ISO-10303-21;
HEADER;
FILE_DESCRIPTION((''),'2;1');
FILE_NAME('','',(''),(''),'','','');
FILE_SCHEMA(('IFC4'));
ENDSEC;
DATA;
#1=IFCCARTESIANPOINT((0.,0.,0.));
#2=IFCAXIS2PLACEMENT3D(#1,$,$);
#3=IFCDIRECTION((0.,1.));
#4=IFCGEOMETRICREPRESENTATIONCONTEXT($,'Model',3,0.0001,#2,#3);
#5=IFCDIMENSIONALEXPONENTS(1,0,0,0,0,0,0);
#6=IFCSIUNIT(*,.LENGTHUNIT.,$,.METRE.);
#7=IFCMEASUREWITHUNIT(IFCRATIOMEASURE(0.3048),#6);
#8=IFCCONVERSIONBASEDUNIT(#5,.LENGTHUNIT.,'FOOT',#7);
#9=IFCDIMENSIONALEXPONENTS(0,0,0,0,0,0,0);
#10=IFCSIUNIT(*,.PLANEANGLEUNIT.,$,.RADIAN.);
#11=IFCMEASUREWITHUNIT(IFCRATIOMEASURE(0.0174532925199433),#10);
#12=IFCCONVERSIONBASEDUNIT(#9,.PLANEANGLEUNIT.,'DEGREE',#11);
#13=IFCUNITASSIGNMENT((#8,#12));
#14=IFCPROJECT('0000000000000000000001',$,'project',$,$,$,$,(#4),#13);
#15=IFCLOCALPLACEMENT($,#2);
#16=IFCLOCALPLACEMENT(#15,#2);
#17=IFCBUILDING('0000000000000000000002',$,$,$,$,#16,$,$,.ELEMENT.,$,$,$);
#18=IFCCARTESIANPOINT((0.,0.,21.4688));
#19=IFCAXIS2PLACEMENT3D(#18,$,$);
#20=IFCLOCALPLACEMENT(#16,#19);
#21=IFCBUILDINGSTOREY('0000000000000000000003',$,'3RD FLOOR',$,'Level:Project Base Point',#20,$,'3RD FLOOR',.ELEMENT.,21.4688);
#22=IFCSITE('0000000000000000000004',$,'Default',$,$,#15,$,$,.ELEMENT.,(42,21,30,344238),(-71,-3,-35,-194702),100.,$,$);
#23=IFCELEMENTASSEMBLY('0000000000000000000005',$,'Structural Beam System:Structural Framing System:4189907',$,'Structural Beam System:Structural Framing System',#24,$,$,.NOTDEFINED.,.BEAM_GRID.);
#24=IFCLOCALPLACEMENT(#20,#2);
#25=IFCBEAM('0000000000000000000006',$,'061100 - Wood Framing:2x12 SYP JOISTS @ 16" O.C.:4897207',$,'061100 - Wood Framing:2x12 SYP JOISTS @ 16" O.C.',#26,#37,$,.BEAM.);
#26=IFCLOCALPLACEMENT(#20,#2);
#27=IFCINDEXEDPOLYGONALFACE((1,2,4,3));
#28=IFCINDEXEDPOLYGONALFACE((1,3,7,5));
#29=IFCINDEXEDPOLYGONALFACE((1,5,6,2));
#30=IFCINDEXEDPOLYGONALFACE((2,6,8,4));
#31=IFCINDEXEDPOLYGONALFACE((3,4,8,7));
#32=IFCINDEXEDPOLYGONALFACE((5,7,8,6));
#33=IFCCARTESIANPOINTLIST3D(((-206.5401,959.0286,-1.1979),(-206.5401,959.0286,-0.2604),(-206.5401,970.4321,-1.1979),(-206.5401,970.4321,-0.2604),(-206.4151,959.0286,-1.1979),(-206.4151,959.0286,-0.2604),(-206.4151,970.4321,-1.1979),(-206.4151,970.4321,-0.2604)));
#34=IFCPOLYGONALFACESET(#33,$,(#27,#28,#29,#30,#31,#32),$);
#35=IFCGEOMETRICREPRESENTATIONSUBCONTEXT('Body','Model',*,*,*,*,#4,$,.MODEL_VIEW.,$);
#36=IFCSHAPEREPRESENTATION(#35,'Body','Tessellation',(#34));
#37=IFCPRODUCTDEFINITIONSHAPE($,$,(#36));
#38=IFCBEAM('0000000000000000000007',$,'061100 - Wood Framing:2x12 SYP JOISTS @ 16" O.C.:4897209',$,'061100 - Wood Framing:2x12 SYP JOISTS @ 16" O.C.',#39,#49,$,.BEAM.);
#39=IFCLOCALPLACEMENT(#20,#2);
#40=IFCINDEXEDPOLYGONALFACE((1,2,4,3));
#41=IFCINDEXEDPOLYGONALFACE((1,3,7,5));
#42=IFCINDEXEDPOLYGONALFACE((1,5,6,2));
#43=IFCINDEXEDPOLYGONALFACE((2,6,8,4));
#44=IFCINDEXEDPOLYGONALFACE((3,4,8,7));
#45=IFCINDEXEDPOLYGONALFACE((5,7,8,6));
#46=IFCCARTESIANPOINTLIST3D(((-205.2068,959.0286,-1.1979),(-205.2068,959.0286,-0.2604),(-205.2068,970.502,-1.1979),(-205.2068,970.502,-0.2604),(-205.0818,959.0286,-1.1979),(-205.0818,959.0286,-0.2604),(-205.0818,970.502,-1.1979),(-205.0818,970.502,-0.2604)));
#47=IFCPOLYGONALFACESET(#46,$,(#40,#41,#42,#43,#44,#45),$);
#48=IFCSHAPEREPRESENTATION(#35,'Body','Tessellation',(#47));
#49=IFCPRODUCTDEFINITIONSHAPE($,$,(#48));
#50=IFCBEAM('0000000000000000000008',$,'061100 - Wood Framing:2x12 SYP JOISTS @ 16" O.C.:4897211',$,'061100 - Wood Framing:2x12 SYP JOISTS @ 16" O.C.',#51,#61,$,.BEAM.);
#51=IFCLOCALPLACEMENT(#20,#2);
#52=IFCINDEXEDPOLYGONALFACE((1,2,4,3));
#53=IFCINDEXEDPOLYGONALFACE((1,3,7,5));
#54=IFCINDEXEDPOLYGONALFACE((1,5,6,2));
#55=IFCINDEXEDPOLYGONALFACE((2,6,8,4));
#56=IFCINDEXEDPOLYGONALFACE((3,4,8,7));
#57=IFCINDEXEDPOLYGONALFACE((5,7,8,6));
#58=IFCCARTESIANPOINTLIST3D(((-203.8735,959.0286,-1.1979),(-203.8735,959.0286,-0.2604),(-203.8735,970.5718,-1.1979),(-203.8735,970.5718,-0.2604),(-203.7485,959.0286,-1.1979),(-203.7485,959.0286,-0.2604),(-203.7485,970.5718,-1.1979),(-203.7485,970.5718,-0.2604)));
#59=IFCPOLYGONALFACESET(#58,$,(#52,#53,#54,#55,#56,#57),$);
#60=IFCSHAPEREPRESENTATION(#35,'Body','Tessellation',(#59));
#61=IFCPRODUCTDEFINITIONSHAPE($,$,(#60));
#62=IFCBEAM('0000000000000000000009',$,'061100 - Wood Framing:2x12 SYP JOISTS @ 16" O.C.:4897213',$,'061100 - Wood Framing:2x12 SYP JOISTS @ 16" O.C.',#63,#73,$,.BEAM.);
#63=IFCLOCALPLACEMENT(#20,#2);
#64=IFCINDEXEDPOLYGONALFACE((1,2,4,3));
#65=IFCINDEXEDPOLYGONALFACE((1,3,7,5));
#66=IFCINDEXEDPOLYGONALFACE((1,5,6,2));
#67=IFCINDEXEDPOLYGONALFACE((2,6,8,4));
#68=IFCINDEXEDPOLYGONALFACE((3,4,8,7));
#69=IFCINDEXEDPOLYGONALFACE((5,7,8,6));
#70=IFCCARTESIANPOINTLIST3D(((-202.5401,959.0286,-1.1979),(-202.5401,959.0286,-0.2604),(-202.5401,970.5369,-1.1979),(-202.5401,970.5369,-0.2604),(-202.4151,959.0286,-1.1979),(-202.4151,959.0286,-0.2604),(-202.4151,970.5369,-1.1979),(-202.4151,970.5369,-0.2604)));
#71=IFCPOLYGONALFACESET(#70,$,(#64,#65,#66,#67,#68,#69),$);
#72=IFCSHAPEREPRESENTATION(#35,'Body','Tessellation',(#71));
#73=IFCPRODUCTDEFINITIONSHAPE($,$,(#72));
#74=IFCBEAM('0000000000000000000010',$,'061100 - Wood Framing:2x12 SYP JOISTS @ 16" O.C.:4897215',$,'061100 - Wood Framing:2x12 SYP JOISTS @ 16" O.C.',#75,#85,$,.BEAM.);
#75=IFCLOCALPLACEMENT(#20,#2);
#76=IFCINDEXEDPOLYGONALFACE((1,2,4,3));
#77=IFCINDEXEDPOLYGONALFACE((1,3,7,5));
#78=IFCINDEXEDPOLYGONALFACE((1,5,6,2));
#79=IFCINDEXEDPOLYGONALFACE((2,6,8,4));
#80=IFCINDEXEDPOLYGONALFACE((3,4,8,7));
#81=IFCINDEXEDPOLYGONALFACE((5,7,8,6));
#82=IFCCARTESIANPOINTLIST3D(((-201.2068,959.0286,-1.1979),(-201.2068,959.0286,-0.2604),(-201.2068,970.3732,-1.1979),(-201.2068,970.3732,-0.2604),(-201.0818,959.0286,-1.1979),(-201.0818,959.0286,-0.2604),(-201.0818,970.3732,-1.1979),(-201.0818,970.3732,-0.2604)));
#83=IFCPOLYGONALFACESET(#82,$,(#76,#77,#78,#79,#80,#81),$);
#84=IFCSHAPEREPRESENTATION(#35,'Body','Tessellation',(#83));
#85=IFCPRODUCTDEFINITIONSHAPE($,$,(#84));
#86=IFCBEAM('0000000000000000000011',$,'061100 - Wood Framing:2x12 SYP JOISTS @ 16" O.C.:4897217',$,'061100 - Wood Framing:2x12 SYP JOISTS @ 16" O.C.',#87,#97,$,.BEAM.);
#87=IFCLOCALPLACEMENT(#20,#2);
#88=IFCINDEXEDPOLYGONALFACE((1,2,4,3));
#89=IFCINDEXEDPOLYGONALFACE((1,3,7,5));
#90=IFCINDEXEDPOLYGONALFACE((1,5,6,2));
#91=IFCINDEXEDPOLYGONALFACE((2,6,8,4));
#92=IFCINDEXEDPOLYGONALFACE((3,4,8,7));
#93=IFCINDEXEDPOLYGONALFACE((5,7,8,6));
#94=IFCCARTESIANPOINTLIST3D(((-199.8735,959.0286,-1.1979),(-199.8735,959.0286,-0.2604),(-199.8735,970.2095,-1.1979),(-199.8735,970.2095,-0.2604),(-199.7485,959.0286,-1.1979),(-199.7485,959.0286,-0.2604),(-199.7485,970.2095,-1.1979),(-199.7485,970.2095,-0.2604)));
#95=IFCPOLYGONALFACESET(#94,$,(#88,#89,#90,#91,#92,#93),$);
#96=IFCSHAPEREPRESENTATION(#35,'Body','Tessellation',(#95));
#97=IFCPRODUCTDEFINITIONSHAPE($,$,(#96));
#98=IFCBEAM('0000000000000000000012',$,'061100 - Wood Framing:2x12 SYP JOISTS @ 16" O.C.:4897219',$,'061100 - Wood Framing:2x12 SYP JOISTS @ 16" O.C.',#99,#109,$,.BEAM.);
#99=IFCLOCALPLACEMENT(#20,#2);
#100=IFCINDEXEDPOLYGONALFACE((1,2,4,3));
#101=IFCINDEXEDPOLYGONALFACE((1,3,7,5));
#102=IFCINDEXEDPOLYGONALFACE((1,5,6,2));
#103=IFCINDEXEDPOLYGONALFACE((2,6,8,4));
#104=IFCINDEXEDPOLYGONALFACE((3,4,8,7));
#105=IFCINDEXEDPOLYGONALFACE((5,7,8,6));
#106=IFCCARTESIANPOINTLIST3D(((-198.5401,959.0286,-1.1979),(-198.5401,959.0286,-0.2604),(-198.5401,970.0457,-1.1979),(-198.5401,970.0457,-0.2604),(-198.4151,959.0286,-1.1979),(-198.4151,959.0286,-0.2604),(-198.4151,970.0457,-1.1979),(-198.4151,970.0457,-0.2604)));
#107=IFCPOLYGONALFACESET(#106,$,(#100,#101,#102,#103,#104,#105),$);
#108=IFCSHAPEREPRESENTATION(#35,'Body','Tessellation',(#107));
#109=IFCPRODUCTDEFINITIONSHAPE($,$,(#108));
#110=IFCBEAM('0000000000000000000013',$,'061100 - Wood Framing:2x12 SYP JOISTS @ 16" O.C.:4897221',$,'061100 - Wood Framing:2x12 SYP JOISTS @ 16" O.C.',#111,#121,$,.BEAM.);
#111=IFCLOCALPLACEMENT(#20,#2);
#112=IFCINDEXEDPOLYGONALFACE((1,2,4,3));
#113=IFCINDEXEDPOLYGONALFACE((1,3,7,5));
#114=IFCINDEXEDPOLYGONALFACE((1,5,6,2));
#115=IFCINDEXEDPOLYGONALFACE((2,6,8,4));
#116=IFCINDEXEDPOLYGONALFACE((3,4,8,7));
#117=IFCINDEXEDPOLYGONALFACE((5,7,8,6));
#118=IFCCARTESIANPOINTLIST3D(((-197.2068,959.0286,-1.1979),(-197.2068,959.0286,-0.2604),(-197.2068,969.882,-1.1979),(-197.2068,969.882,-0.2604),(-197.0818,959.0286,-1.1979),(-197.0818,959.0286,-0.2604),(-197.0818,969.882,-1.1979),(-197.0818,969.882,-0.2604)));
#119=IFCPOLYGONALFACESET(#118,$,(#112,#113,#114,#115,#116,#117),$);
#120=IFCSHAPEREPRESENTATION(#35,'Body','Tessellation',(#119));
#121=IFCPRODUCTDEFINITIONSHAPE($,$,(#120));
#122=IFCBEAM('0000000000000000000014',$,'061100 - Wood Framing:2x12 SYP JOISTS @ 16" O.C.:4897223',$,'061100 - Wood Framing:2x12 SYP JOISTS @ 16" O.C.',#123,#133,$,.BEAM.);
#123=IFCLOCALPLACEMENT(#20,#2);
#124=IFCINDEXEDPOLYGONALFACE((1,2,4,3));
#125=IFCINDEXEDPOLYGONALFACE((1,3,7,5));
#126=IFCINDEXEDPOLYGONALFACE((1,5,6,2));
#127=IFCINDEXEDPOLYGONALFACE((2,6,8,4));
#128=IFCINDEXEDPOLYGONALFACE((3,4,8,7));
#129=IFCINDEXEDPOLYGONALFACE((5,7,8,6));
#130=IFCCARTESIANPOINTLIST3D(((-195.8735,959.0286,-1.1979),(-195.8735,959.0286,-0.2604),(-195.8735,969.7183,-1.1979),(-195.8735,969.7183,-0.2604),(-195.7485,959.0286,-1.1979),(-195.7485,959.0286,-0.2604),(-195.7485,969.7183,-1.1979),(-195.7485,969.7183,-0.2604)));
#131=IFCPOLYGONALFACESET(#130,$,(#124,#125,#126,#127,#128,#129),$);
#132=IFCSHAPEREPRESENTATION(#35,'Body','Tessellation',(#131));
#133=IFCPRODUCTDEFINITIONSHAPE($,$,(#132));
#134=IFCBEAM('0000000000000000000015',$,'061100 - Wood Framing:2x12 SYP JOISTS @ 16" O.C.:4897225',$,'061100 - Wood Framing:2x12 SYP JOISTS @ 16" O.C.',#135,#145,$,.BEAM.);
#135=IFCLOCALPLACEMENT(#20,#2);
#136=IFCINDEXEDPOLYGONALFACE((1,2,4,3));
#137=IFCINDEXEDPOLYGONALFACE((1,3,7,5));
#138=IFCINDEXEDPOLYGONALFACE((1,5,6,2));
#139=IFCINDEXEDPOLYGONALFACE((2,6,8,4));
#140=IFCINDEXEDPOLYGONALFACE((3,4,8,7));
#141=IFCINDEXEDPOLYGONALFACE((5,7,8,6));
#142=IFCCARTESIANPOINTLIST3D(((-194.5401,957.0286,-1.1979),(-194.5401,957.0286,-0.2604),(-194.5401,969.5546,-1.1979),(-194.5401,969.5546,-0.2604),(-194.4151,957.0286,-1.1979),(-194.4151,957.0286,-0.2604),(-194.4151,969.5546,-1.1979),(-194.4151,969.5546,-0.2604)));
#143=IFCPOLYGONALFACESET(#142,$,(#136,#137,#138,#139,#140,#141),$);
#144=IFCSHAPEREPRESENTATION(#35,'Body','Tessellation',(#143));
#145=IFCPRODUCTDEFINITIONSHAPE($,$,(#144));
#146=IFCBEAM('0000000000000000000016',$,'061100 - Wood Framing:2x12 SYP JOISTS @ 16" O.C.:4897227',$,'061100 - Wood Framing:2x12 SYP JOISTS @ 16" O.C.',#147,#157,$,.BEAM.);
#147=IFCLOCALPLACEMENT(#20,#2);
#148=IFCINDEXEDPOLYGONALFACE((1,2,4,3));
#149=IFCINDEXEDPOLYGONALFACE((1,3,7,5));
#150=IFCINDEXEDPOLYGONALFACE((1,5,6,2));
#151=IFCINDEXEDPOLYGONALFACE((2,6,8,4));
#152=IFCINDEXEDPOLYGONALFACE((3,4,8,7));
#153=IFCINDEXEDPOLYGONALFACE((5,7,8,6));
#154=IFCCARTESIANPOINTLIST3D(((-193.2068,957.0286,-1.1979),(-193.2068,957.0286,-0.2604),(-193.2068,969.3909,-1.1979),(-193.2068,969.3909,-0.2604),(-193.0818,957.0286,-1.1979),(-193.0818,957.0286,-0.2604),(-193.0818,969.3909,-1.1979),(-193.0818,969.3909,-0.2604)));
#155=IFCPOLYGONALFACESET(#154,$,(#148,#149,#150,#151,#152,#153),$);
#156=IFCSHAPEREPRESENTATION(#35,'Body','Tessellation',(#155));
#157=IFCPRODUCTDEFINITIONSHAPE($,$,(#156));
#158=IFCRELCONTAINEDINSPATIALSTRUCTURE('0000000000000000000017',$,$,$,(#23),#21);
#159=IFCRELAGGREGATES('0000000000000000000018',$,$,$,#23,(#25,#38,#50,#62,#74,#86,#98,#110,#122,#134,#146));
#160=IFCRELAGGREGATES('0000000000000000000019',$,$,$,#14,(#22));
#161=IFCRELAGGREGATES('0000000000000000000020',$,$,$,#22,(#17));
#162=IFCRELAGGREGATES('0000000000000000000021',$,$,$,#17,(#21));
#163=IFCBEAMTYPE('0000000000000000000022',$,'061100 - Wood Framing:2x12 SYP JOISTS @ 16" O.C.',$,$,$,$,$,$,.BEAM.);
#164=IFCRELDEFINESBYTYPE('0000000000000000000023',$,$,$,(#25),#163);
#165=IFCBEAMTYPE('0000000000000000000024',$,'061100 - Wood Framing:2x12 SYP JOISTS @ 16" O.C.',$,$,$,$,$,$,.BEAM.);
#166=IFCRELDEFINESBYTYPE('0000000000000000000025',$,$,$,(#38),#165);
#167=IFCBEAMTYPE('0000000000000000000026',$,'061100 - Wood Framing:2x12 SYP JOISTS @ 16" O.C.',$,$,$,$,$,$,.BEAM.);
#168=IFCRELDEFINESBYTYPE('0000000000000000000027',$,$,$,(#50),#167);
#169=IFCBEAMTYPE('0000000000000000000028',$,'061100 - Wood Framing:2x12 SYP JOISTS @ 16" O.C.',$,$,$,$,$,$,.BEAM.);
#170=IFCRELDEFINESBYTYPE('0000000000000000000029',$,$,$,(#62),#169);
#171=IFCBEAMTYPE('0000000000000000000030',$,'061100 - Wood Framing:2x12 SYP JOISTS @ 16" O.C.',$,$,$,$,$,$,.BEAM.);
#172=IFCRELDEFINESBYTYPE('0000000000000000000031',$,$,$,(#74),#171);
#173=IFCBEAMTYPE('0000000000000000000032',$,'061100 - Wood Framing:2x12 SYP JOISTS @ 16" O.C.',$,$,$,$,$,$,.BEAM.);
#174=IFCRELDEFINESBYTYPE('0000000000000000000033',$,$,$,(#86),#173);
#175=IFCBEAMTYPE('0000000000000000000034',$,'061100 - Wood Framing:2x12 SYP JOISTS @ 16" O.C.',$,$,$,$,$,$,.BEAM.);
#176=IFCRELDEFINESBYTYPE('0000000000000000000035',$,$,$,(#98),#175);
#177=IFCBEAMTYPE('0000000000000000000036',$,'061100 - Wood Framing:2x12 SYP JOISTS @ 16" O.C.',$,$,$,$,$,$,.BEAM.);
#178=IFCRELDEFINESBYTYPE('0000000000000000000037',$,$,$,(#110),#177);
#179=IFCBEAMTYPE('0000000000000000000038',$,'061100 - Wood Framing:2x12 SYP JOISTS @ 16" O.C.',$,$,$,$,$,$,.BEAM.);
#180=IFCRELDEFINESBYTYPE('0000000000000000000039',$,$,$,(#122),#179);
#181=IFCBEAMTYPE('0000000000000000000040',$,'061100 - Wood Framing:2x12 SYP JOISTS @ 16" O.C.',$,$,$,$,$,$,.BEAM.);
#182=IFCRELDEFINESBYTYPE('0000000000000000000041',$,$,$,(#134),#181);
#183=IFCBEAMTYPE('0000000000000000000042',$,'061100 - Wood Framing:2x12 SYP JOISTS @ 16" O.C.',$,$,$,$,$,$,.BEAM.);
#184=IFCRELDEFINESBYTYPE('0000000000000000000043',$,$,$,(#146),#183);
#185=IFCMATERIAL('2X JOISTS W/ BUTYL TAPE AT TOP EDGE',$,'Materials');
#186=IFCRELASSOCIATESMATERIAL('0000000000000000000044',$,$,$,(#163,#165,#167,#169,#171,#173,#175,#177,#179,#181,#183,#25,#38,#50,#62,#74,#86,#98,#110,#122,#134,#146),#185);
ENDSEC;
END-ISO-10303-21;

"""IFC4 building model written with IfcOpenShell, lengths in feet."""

from ifc_helpers import new_model, entity, si_unit, converted_unit, direction, frame, origin, origin_2d_with_axis, place, context, subcontext, project, spatial, rectangle, extrude, source, transform, mapped, material, material_profile, profile_set, profile_usage, type_object, type_shapes, element, aggregate, save


model = new_model("IFC4")

# Units and contexts
model_context = context("Model", 3, precision=0.0001, world=origin(), true_north=direction((0.0, 1.0)))
body_context = subcontext(model_context, "Body", "Model", "MODEL_VIEW")
ifc_project = project(units=[converted_unit("LENGTHUNIT", "FOOT", entity("IfcRatioMeasure", 0.3048), si_unit("LENGTHUNIT", "METRE"), dimensions=[1, 0, 0, 0, 0, 0, 0]), converted_unit("PLANEANGLEUNIT", "DEGREE", entity("IfcRatioMeasure", 0.0174532925199433), si_unit("PLANEANGLEUNIT", "RADIAN"), dimensions=[0, 0, 0, 0, 0, 0, 0])], contexts=[model_context])

# Site, building, storey
site_placement = place(None, origin())
site = spatial("IfcSite", under=ifc_project, at=site_placement, Name="Default", CompositionType="ELEMENT", RefLatitude=(42, 21, 30, 344238), RefLongitude=(-71, -3, -35, -194702), RefElevation=100.0)
building_placement = place(site_placement, origin())
building = spatial("IfcBuilding", under=site, at=building_placement, CompositionType="ELEMENT")
storey_placement = place(building_placement, frame((0.0, 0.0, 21.4688)))
storey = spatial("IfcBuildingStorey", under=building, at=storey_placement, Name="3RD FLOOR", ObjectType="Level:Project Base Point", LongName="3RD FLOOR", CompositionType="ELEMENT", Elevation=21.4688)

# Element assembly, beams
assembly_1_placement = place(storey_placement, origin())
assembly_1 = element("IfcElementAssembly", 1, at=assembly_1_placement, inside=storey, Name="Structural Beam System:Structural Framing System:4189907", ObjectType="Structural Beam System:Structural Framing System", AssemblyPlace="NOTDEFINED", PredefinedType="BEAM_GRID")
ifc_material_1 = material(Name="2X JOISTS W/ BUTYL TAPE AT TOP EDGE", Category="Materials")
ifc_material_profile_1 = material_profile(ifc_material_1, rectangle(XDim=0.9375, YDim=0.125, at=origin_2d_with_axis()), Name="2x12 SYP JOISTS @ 16\" O.C.")
ifc_profile_set_1 = profile_set([ifc_material_profile_1], Name="2x12 SYP JOISTS @ 16\" O.C.")
ifc_profile_usage_1 = profile_usage(ifc_profile_set_1, cardinal=8)
beam_type_1 = type_object("IfcBeamType", Name="061100 - Wood Framing:2x12 SYP JOISTS @ 16\" O.C.", PredefinedType="BEAM", material=ifc_profile_set_1)
shared_shape_1 = source(origin(), body_context, "Body", "SweptSolid", [
    extrude(rectangle(XDim=0.9375, YDim=0.125, at=origin_2d_with_axis()), frame((-5.7017, 0.0, 0.0), z_axis=(1.0, 0.0, 0.0), x_axis=(0.0, 0.0, -1.0)), (0.0, 0.0, 1.0), 11.4035),
])
type_shapes(beam_type_1, [shared_shape_1])
beam_1_placement = place(assembly_1_placement, frame((-206.4776, 964.7303, -0.7292), z_axis=(0.0, 0.0, 1.0), x_axis=(0.0, 1.0, 0.0)))
beam_1 = element("IfcBeam", 2, at=beam_1_placement, type_object=beam_type_1, material=ifc_profile_usage_1, Name="061100 - Wood Framing:2x12 SYP JOISTS @ 16\" O.C.:4897207", ObjectType="061100 - Wood Framing:2x12 SYP JOISTS @ 16\" O.C.", PredefinedType="BEAM", context=body_context, shape_type="MappedRepresentation", body=[
    mapped(shared_shape_1, transform((0.0, 0.0, 0.0), scale=1.0)),
])
ifc_profile_usage_2 = profile_usage(ifc_profile_set_1, cardinal=8)
beam_type_2 = type_object("IfcBeamType", Name="061100 - Wood Framing:2x12 SYP JOISTS @ 16\" O.C.", PredefinedType="BEAM", material=ifc_profile_set_1)
shared_shape_2 = source(origin(), body_context, "Body", "SweptSolid", [
    extrude(rectangle(XDim=0.9375, YDim=0.125, at=origin_2d_with_axis()), frame((-5.7367, 0.0, 0.0), z_axis=(1.0, 0.0, 0.0), x_axis=(0.0, 0.0, -1.0)), (0.0, 0.0, 1.0), 11.4734),
])
type_shapes(beam_type_2, [shared_shape_2])
beam_2_placement = place(assembly_1_placement, frame((-205.1443, 964.7653, -0.7292), z_axis=(0.0, 0.0, 1.0), x_axis=(0.0, 1.0, 0.0)))
beam_2 = element("IfcBeam", 3, at=beam_2_placement, type_object=beam_type_2, material=ifc_profile_usage_2, Name="061100 - Wood Framing:2x12 SYP JOISTS @ 16\" O.C.:4897209", ObjectType="061100 - Wood Framing:2x12 SYP JOISTS @ 16\" O.C.", PredefinedType="BEAM", context=body_context, shape_type="MappedRepresentation", body=[
    mapped(shared_shape_2, transform((0.0, 0.0, 0.0), scale=1.0)),
])
ifc_profile_usage_3 = profile_usage(ifc_profile_set_1, cardinal=8)
beam_type_3 = type_object("IfcBeamType", Name="061100 - Wood Framing:2x12 SYP JOISTS @ 16\" O.C.", PredefinedType="BEAM", material=ifc_profile_set_1)
shared_shape_3 = source(origin(), body_context, "Body", "SweptSolid", [
    extrude(rectangle(XDim=0.9375, YDim=0.125, at=origin_2d_with_axis()), frame((-5.7716, 0.0, 0.0), z_axis=(1.0, 0.0, 0.0), x_axis=(0.0, 0.0, -1.0)), (0.0, 0.0, 1.0), 11.5432),
])
type_shapes(beam_type_3, [shared_shape_3])
beam_3_placement = place(assembly_1_placement, frame((-203.811, 964.8002, -0.7292), z_axis=(0.0, 0.0, 1.0), x_axis=(0.0, 1.0, 0.0)))
beam_3 = element("IfcBeam", 4, at=beam_3_placement, type_object=beam_type_3, material=ifc_profile_usage_3, Name="061100 - Wood Framing:2x12 SYP JOISTS @ 16\" O.C.:4897211", ObjectType="061100 - Wood Framing:2x12 SYP JOISTS @ 16\" O.C.", PredefinedType="BEAM", context=body_context, shape_type="MappedRepresentation", body=[
    mapped(shared_shape_3, transform((0.0, 0.0, 0.0), scale=1.0)),
])
ifc_profile_usage_4 = profile_usage(ifc_profile_set_1, cardinal=8)
beam_type_4 = type_object("IfcBeamType", Name="061100 - Wood Framing:2x12 SYP JOISTS @ 16\" O.C.", PredefinedType="BEAM", material=ifc_profile_set_1)
shared_shape_4 = source(origin(), body_context, "Body", "SweptSolid", [
    extrude(rectangle(XDim=0.9375, YDim=0.125, at=origin_2d_with_axis()), frame((-5.7541, 0.0, 0.0), z_axis=(1.0, 0.0, 0.0), x_axis=(0.0, 0.0, -1.0)), (0.0, 0.0, 1.0), 11.5083),
])
type_shapes(beam_type_4, [shared_shape_4])
beam_4_placement = place(assembly_1_placement, frame((-202.4776, 964.7827, -0.7292), z_axis=(0.0, 0.0, 1.0), x_axis=(0.0, 1.0, 0.0)))
beam_4 = element("IfcBeam", 5, at=beam_4_placement, type_object=beam_type_4, material=ifc_profile_usage_4, Name="061100 - Wood Framing:2x12 SYP JOISTS @ 16\" O.C.:4897213", ObjectType="061100 - Wood Framing:2x12 SYP JOISTS @ 16\" O.C.", PredefinedType="BEAM", context=body_context, shape_type="MappedRepresentation", body=[
    mapped(shared_shape_4, transform((0.0, 0.0, 0.0), scale=1.0)),
])
ifc_profile_usage_5 = profile_usage(ifc_profile_set_1, cardinal=8)
beam_type_5 = type_object("IfcBeamType", Name="061100 - Wood Framing:2x12 SYP JOISTS @ 16\" O.C.", PredefinedType="BEAM", material=ifc_profile_set_1)
shared_shape_5 = source(origin(), body_context, "Body", "SweptSolid", [
    extrude(rectangle(XDim=0.9375, YDim=0.125, at=origin_2d_with_axis()), frame((-5.6723, 0.0, 0.0), z_axis=(1.0, 0.0, 0.0), x_axis=(0.0, 0.0, -1.0)), (0.0, 0.0, 1.0), 11.3446),
])
type_shapes(beam_type_5, [shared_shape_5])
beam_5_placement = place(assembly_1_placement, frame((-201.1443, 964.7009, -0.7292), z_axis=(0.0, 0.0, 1.0), x_axis=(0.0, 1.0, 0.0)))
beam_5 = element("IfcBeam", 6, at=beam_5_placement, type_object=beam_type_5, material=ifc_profile_usage_5, Name="061100 - Wood Framing:2x12 SYP JOISTS @ 16\" O.C.:4897215", ObjectType="061100 - Wood Framing:2x12 SYP JOISTS @ 16\" O.C.", PredefinedType="BEAM", context=body_context, shape_type="MappedRepresentation", body=[
    mapped(shared_shape_5, transform((0.0, 0.0, 0.0), scale=1.0)),
])
ifc_profile_usage_6 = profile_usage(ifc_profile_set_1, cardinal=8)
beam_type_6 = type_object("IfcBeamType", Name="061100 - Wood Framing:2x12 SYP JOISTS @ 16\" O.C.", PredefinedType="BEAM", material=ifc_profile_set_1)
shared_shape_6 = source(origin(), body_context, "Body", "SweptSolid", [
    extrude(rectangle(XDim=0.9375, YDim=0.125, at=origin_2d_with_axis()), frame((-5.5904, 0.0, 0.0), z_axis=(1.0, 0.0, 0.0), x_axis=(0.0, 0.0, -1.0)), (0.0, 0.0, 1.0), 11.1809),
])
type_shapes(beam_type_6, [shared_shape_6])
beam_6_placement = place(assembly_1_placement, frame((-199.811, 964.619, -0.7292), z_axis=(0.0, 0.0, 1.0), x_axis=(0.0, 1.0, 0.0)))
beam_6 = element("IfcBeam", 7, at=beam_6_placement, type_object=beam_type_6, material=ifc_profile_usage_6, Name="061100 - Wood Framing:2x12 SYP JOISTS @ 16\" O.C.:4897217", ObjectType="061100 - Wood Framing:2x12 SYP JOISTS @ 16\" O.C.", PredefinedType="BEAM", context=body_context, shape_type="MappedRepresentation", body=[
    mapped(shared_shape_6, transform((0.0, 0.0, 0.0), scale=1.0)),
])
ifc_profile_usage_7 = profile_usage(ifc_profile_set_1, cardinal=8)
beam_type_7 = type_object("IfcBeamType", Name="061100 - Wood Framing:2x12 SYP JOISTS @ 16\" O.C.", PredefinedType="BEAM", material=ifc_profile_set_1)
shared_shape_7 = source(origin(), body_context, "Body", "SweptSolid", [
    extrude(rectangle(XDim=0.9375, YDim=0.125, at=origin_2d_with_axis()), frame((-5.5086, 0.0, 0.0), z_axis=(1.0, 0.0, 0.0), x_axis=(0.0, 0.0, -1.0)), (0.0, 0.0, 1.0), 11.0171),
])
type_shapes(beam_type_7, [shared_shape_7])
beam_7_placement = place(assembly_1_placement, frame((-198.4776, 964.5372, -0.7292), z_axis=(0.0, 0.0, 1.0), x_axis=(0.0, 1.0, 0.0)))
beam_7 = element("IfcBeam", 8, at=beam_7_placement, type_object=beam_type_7, material=ifc_profile_usage_7, Name="061100 - Wood Framing:2x12 SYP JOISTS @ 16\" O.C.:4897219", ObjectType="061100 - Wood Framing:2x12 SYP JOISTS @ 16\" O.C.", PredefinedType="BEAM", context=body_context, shape_type="MappedRepresentation", body=[
    mapped(shared_shape_7, transform((0.0, 0.0, 0.0), scale=1.0)),
])
ifc_profile_usage_8 = profile_usage(ifc_profile_set_1, cardinal=8)
beam_type_8 = type_object("IfcBeamType", Name="061100 - Wood Framing:2x12 SYP JOISTS @ 16\" O.C.", PredefinedType="BEAM", material=ifc_profile_set_1)
shared_shape_8 = source(origin(), body_context, "Body", "SweptSolid", [
    extrude(rectangle(XDim=0.9375, YDim=0.125, at=origin_2d_with_axis()), frame((-5.4267, 0.0, 0.0), z_axis=(1.0, 0.0, 0.0), x_axis=(0.0, 0.0, -1.0)), (0.0, 0.0, 1.0), 10.8534),
])
type_shapes(beam_type_8, [shared_shape_8])
beam_8_placement = place(assembly_1_placement, frame((-197.1443, 964.4553, -0.7292), z_axis=(0.0, 0.0, 1.0), x_axis=(0.0, 1.0, 0.0)))
beam_8 = element("IfcBeam", 9, at=beam_8_placement, type_object=beam_type_8, material=ifc_profile_usage_8, Name="061100 - Wood Framing:2x12 SYP JOISTS @ 16\" O.C.:4897221", ObjectType="061100 - Wood Framing:2x12 SYP JOISTS @ 16\" O.C.", PredefinedType="BEAM", context=body_context, shape_type="MappedRepresentation", body=[
    mapped(shared_shape_8, transform((0.0, 0.0, 0.0), scale=1.0)),
])
ifc_profile_usage_9 = profile_usage(ifc_profile_set_1, cardinal=8)
beam_type_9 = type_object("IfcBeamType", Name="061100 - Wood Framing:2x12 SYP JOISTS @ 16\" O.C.", PredefinedType="BEAM", material=ifc_profile_set_1)
shared_shape_9 = source(origin(), body_context, "Body", "SweptSolid", [
    extrude(rectangle(XDim=0.9375, YDim=0.125, at=origin_2d_with_axis()), frame((-5.3449, 0.0, 0.0), z_axis=(1.0, 0.0, 0.0), x_axis=(0.0, 0.0, -1.0)), (0.0, 0.0, 1.0), 10.6897),
])
type_shapes(beam_type_9, [shared_shape_9])
beam_9_placement = place(assembly_1_placement, frame((-195.811, 964.3735, -0.7292), z_axis=(0.0, 0.0, 1.0), x_axis=(0.0, 1.0, 0.0)))
beam_9 = element("IfcBeam", 10, at=beam_9_placement, type_object=beam_type_9, material=ifc_profile_usage_9, Name="061100 - Wood Framing:2x12 SYP JOISTS @ 16\" O.C.:4897223", ObjectType="061100 - Wood Framing:2x12 SYP JOISTS @ 16\" O.C.", PredefinedType="BEAM", context=body_context, shape_type="MappedRepresentation", body=[
    mapped(shared_shape_9, transform((0.0, 0.0, 0.0), scale=1.0)),
])
ifc_profile_usage_10 = profile_usage(ifc_profile_set_1, cardinal=8)
beam_type_10 = type_object("IfcBeamType", Name="061100 - Wood Framing:2x12 SYP JOISTS @ 16\" O.C.", PredefinedType="BEAM", material=ifc_profile_set_1)
shared_shape_10 = source(origin(), body_context, "Body", "SweptSolid", [
    extrude(rectangle(XDim=0.9375, YDim=0.125, at=origin_2d_with_axis()), frame((-6.263, 0.0, 0.0), z_axis=(1.0, 0.0, 0.0), x_axis=(0.0, 0.0, -1.0)), (0.0, 0.0, 1.0), 12.526),
])
type_shapes(beam_type_10, [shared_shape_10])
beam_10_placement = place(assembly_1_placement, frame((-194.4776, 963.2916, -0.7292), z_axis=(0.0, 0.0, 1.0), x_axis=(0.0, 1.0, 0.0)))
beam_10 = element("IfcBeam", 11, at=beam_10_placement, type_object=beam_type_10, material=ifc_profile_usage_10, Name="061100 - Wood Framing:2x12 SYP JOISTS @ 16\" O.C.:4897225", ObjectType="061100 - Wood Framing:2x12 SYP JOISTS @ 16\" O.C.", PredefinedType="BEAM", context=body_context, shape_type="MappedRepresentation", body=[
    mapped(shared_shape_10, transform((0.0, 0.0, 0.0), scale=1.0)),
])
ifc_profile_usage_11 = profile_usage(ifc_profile_set_1, cardinal=8)
beam_type_11 = type_object("IfcBeamType", Name="061100 - Wood Framing:2x12 SYP JOISTS @ 16\" O.C.", PredefinedType="BEAM", material=ifc_profile_set_1)
shared_shape_11 = source(origin(), body_context, "Body", "SweptSolid", [
    extrude(rectangle(XDim=0.9375, YDim=0.125, at=origin_2d_with_axis()), frame((-6.1811, 0.0, 0.0), z_axis=(1.0, 0.0, 0.0), x_axis=(0.0, 0.0, -1.0)), (0.0, 0.0, 1.0), 12.3623),
])
type_shapes(beam_type_11, [shared_shape_11])
beam_11_placement = place(assembly_1_placement, frame((-193.1443, 963.2097, -0.7292), z_axis=(0.0, 0.0, 1.0), x_axis=(0.0, 1.0, 0.0)))
beam_11 = element("IfcBeam", 12, at=beam_11_placement, type_object=beam_type_11, material=ifc_profile_usage_11, Name="061100 - Wood Framing:2x12 SYP JOISTS @ 16\" O.C.:4897227", ObjectType="061100 - Wood Framing:2x12 SYP JOISTS @ 16\" O.C.", PredefinedType="BEAM", context=body_context, shape_type="MappedRepresentation", body=[
    mapped(shared_shape_11, transform((0.0, 0.0, 0.0), scale=1.0)),
])
aggregate(assembly_1, [beam_1, beam_2, beam_3, beam_4, beam_5, beam_6, beam_7, beam_8, beam_9, beam_10, beam_11])

save(model, "model.ifc")
